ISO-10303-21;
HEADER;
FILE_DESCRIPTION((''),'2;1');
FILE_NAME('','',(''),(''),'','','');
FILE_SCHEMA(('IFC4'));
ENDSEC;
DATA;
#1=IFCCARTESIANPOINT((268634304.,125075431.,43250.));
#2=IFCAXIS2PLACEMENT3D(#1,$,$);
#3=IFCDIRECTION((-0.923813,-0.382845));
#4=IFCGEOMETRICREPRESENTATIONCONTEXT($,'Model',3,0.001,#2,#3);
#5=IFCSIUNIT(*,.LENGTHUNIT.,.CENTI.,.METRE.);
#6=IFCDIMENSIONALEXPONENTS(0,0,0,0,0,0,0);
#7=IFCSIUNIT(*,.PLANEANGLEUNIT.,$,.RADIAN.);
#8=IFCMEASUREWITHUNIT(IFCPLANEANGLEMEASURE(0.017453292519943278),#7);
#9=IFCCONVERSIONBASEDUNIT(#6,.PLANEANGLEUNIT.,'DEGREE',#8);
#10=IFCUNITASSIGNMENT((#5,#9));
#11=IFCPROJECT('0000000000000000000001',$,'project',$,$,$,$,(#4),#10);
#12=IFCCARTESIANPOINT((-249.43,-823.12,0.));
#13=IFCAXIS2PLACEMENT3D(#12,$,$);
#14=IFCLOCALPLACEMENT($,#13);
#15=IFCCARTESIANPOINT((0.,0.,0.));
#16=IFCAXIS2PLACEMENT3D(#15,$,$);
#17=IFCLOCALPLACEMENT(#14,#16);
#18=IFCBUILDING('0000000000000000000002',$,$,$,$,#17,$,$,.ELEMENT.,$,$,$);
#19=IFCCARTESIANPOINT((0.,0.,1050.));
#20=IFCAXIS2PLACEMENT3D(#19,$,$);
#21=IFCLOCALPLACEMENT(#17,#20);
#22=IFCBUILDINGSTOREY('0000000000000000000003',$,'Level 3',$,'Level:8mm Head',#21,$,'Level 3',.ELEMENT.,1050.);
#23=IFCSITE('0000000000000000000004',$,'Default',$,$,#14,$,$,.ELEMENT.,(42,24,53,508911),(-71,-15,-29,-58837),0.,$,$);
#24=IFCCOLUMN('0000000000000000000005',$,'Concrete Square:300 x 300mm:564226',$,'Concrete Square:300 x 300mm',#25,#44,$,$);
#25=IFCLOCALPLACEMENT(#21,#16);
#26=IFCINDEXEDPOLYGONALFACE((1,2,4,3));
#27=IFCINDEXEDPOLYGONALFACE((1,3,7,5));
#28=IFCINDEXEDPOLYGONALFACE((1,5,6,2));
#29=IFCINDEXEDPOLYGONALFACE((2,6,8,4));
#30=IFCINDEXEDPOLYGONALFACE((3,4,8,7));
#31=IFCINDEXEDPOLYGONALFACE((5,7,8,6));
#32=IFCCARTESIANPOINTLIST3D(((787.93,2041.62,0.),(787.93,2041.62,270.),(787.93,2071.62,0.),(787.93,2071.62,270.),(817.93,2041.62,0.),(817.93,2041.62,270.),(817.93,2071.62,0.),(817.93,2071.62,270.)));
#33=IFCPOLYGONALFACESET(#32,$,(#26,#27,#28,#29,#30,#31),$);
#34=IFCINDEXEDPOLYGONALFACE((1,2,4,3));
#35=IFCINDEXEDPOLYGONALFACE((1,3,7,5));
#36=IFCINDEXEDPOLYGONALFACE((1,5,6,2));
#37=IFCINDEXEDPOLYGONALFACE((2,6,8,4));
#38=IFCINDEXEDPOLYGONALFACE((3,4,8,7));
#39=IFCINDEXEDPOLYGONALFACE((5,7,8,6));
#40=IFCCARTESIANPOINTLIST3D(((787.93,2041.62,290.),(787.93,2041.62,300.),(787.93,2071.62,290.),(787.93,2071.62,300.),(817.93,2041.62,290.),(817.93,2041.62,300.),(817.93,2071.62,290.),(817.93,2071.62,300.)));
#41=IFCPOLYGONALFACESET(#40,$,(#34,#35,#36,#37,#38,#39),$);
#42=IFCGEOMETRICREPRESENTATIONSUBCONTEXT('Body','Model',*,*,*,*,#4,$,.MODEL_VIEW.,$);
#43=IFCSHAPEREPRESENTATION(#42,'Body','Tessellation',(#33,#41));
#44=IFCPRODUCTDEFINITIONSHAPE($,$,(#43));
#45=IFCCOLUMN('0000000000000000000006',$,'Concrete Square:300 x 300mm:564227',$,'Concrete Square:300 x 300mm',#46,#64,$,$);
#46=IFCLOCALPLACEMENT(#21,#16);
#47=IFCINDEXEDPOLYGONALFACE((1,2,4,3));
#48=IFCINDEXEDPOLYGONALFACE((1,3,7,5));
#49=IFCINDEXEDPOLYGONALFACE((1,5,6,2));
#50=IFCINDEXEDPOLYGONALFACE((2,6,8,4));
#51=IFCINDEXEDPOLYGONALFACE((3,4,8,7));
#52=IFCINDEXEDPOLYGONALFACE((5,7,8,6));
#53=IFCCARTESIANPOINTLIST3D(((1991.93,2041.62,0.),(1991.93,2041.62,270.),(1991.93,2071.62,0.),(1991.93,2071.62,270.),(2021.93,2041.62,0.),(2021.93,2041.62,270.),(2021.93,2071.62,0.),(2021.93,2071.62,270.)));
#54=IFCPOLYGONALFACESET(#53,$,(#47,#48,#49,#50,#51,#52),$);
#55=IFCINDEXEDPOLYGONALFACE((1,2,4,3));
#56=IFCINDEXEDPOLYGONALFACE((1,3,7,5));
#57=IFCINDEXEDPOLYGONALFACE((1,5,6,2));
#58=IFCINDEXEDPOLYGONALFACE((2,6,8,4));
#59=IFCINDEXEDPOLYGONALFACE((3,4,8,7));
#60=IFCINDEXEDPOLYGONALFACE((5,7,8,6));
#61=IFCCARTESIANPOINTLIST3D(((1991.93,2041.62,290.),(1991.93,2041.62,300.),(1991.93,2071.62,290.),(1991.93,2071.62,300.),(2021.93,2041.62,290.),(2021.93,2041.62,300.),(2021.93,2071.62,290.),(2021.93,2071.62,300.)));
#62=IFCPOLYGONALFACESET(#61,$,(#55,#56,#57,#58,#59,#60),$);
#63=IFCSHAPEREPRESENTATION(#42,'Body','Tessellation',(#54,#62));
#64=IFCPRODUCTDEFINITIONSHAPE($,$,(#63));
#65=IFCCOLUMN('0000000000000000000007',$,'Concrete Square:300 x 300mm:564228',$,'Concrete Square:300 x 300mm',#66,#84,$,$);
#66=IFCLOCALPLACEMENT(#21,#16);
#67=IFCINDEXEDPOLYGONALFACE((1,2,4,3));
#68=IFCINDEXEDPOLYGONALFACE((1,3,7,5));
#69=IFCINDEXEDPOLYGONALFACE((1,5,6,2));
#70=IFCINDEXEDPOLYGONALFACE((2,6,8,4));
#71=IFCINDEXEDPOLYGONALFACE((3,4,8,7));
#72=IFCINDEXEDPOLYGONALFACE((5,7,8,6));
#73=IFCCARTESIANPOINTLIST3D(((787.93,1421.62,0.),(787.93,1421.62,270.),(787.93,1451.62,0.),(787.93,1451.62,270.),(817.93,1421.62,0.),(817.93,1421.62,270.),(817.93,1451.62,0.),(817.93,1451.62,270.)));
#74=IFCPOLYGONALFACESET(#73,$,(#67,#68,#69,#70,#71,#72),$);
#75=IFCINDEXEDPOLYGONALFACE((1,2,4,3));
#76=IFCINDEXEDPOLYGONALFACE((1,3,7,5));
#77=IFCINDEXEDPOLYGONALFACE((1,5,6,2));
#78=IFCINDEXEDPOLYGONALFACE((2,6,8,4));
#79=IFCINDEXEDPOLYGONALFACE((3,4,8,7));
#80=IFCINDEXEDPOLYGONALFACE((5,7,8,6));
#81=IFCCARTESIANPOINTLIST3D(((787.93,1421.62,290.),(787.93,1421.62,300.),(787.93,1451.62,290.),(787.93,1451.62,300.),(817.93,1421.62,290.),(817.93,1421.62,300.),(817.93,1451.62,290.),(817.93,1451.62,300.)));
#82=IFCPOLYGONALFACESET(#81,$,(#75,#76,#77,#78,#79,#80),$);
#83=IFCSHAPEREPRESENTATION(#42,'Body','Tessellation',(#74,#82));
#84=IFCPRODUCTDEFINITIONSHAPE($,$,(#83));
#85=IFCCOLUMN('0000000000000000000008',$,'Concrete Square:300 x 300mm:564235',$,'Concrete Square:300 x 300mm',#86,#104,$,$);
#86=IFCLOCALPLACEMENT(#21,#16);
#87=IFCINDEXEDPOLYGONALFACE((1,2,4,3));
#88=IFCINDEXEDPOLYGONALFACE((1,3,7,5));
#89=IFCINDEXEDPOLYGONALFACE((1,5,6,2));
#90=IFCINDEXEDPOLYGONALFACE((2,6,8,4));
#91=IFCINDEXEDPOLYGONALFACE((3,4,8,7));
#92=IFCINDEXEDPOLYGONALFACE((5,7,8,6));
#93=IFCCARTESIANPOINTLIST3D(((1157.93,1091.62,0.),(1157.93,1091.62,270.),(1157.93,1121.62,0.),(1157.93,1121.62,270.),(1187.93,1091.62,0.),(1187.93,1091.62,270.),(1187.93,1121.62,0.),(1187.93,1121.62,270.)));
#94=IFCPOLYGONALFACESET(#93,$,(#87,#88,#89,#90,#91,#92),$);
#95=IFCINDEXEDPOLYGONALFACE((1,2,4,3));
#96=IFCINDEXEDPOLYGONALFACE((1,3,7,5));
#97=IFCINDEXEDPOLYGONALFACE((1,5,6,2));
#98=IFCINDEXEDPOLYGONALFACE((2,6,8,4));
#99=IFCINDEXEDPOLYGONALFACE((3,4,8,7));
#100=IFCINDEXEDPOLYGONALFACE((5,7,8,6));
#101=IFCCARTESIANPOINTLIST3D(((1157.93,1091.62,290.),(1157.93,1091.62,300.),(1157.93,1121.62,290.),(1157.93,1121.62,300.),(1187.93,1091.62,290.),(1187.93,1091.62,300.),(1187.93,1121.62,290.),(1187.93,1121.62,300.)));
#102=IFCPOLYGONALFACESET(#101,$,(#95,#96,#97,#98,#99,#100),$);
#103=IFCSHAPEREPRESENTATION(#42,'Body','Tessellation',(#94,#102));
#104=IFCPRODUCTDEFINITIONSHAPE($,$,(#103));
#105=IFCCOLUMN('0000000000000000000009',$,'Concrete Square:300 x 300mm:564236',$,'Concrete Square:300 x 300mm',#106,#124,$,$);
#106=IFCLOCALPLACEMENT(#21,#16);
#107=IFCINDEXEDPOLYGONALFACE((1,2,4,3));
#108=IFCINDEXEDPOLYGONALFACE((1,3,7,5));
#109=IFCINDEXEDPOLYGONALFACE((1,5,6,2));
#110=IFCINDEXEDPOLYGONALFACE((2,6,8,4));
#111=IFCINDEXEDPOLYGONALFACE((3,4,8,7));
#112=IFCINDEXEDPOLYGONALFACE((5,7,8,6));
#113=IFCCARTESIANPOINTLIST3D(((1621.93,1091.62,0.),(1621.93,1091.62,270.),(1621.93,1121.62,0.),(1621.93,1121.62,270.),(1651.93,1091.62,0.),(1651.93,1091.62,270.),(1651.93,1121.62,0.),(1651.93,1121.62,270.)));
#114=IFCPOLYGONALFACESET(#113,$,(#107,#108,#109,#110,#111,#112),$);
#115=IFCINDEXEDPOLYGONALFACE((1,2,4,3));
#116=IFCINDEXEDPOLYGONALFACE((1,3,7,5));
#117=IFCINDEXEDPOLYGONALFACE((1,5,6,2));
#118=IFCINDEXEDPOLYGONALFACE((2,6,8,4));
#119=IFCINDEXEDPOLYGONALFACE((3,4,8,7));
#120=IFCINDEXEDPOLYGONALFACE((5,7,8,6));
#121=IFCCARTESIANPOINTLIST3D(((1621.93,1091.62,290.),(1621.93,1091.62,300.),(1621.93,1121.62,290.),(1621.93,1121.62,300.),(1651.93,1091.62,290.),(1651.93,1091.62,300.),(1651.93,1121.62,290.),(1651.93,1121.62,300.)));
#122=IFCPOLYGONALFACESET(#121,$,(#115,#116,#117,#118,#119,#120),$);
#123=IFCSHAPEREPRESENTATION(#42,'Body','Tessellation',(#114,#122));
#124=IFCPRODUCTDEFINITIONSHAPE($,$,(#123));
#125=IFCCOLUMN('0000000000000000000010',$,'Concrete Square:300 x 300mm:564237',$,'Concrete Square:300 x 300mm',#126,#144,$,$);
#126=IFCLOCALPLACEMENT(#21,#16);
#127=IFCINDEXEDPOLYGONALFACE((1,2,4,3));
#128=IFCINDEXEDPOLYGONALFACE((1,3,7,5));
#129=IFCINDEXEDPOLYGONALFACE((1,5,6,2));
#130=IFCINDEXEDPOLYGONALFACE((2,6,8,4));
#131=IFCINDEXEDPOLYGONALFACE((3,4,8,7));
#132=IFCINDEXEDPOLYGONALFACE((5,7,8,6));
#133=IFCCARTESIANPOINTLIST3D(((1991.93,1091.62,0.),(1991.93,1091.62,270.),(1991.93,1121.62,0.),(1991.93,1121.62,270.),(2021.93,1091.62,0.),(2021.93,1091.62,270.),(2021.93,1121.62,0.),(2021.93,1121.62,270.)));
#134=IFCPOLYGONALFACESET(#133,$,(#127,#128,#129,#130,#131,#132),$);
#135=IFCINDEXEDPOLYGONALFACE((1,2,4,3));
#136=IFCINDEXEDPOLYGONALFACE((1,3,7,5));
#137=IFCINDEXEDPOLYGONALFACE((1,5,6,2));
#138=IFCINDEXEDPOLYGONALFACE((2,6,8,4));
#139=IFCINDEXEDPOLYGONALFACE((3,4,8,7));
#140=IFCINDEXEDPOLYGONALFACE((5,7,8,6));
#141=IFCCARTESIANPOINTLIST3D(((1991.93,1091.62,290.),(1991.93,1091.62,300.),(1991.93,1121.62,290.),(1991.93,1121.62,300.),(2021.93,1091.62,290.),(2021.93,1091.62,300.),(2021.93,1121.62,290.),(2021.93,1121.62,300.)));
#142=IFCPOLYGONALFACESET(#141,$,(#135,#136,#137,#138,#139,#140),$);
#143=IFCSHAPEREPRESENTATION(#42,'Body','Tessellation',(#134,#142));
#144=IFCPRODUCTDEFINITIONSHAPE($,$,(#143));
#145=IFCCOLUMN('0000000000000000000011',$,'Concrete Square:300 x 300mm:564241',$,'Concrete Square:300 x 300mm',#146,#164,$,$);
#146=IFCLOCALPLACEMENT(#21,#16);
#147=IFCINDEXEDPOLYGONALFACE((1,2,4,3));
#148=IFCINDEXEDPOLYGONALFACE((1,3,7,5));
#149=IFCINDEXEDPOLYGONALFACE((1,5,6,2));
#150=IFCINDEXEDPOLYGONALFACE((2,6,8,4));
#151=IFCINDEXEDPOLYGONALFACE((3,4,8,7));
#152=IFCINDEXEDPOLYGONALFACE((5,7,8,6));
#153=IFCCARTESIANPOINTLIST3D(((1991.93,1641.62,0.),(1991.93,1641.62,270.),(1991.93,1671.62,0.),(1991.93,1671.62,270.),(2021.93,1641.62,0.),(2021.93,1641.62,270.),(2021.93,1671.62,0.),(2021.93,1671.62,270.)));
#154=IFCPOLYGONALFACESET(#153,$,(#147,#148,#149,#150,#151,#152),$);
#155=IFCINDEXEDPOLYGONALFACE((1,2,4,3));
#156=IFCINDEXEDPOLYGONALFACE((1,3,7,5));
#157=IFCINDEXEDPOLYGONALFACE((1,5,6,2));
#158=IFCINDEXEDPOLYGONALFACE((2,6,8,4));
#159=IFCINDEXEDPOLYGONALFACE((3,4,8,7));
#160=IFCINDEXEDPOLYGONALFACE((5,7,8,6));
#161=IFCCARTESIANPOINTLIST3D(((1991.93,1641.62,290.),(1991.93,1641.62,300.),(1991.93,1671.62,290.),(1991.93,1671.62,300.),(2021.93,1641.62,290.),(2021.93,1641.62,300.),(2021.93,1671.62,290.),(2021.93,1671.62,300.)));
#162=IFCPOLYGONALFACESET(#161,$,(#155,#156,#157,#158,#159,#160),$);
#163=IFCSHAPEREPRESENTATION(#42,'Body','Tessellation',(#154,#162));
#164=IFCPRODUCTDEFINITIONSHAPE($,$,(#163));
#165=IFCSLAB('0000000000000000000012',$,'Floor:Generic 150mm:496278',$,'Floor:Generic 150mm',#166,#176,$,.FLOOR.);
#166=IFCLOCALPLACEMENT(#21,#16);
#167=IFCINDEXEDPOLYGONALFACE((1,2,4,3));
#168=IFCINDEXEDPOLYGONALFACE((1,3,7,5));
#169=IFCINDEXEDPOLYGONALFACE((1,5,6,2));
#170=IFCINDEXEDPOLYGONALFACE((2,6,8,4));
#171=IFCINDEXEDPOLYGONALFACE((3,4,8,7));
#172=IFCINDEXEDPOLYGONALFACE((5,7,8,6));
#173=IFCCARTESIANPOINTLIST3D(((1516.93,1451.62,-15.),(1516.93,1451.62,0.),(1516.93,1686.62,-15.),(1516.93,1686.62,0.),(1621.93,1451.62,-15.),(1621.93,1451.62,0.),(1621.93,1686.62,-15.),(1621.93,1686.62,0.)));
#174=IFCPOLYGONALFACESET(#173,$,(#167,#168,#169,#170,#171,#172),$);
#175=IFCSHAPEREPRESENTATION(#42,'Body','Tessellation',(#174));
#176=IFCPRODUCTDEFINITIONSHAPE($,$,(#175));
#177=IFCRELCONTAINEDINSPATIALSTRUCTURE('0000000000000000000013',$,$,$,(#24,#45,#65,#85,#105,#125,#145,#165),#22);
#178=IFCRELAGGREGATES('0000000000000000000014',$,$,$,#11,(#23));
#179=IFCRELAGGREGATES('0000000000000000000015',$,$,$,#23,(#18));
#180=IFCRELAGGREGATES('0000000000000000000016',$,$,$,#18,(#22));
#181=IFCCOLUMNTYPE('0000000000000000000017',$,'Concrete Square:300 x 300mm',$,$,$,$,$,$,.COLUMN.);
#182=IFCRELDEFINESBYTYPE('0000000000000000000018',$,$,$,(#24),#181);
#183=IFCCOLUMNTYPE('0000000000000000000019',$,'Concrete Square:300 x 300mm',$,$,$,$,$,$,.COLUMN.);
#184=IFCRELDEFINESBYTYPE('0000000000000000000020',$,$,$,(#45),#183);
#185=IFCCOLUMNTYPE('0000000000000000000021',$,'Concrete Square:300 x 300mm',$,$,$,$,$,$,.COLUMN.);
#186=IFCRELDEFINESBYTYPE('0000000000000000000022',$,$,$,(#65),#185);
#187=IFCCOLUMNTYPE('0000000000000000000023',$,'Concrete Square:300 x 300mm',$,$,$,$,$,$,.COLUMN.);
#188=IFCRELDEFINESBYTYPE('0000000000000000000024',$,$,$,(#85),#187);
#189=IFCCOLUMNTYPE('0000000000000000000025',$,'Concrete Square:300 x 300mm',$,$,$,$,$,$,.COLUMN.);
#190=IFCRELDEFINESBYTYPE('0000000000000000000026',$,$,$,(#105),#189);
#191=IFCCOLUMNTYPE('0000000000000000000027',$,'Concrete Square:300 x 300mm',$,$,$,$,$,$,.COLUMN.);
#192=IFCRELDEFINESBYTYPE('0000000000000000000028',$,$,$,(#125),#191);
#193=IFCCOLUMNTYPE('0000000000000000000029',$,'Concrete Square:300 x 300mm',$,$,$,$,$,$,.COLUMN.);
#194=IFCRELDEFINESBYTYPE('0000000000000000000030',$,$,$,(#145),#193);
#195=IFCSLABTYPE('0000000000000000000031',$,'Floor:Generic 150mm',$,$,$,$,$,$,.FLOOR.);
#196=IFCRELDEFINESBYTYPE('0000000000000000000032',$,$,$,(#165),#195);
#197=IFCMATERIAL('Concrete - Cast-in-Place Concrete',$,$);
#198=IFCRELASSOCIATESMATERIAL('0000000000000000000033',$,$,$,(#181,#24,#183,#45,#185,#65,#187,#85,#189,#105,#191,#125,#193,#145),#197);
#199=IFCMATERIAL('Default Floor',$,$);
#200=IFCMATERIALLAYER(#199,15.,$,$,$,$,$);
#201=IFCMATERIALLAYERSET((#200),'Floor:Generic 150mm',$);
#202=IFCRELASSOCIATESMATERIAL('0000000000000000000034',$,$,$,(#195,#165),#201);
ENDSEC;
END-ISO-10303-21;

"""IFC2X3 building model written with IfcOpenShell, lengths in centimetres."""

from ifc_helpers import new_model, entity, si_unit, converted_unit, direction, frame, frame_2d, origin, origin_2d_with_axis, place, context, subcontext, project, spatial, rectangle, extrude, source, transform, mapped, material, layer, layer_set, layer_usage, type_object, type_shapes, element, save


model = new_model("IFC2X3")

# Units and contexts
model_context = context("Model", 3, precision=0.001, world=frame((268634304.0, 125075431.0, 43250.0)), true_north=direction((-0.923813, -0.382845)))
body_context = subcontext(model_context, "Body", "Model", "MODEL_VIEW")
ifc_project = project(units=[si_unit("LENGTHUNIT", "METRE", prefix="CENTI"), converted_unit("PLANEANGLEUNIT", "DEGREE", entity("IfcPlaneAngleMeasure", 0.017453292519943278), si_unit("PLANEANGLEUNIT", "RADIAN"), dimensions=[0, 0, 0, 0, 0, 0, 0])], contexts=[model_context])

# Site, building, storey
site_placement = place(None, frame((-249.43, -823.12, 0.0)))
site = spatial("IfcSite", under=ifc_project, at=site_placement, Name="Default", CompositionType="ELEMENT", RefLatitude=(42, 24, 53, 508911), RefLongitude=(-71, -15, -29, -58837), RefElevation=0.0)
building_placement = place(site_placement, origin())
building = spatial("IfcBuilding", under=site, at=building_placement, CompositionType="ELEMENT")
storey_placement = place(building_placement, frame((0.0, 0.0, 1050.0)))
storey = spatial("IfcBuildingStorey", under=building, at=storey_placement, Name="Level 3", ObjectType="Level:8mm Head", LongName="Level 3", CompositionType="ELEMENT", Elevation=1050.0)

# Columns
ifc_material_1 = material(Name="Concrete - Cast-in-Place Concrete")
column_type_1 = type_object("IfcColumnType", Name="Concrete Square:300 x 300mm", PredefinedType="COLUMN", material=ifc_material_1)
shared_shape_1 = source(origin(), body_context, "Body", "SweptSolid", [
    extrude(rectangle(XDim=30.0, YDim=30.0, at=frame_2d((0.0, 0.0), x_axis=(1.0, 0.0))), frame((802.93, 2056.62, 1050.0), z_axis=(0.0, 0.0, 1.0), x_axis=(-1.0, 0.0, 0.0)), (0.0, 0.0, 1.0), 270.0),
    extrude(rectangle(XDim=30.0, YDim=30.0, at=frame_2d((0.0, 0.0), x_axis=(1.0, 0.0))), frame((802.93, 2056.62, 1340.0), z_axis=(0.0, 0.0, 1.0), x_axis=(-1.0, 0.0, 0.0)), (0.0, 0.0, 1.0), 10.0),
])
type_shapes(column_type_1, [shared_shape_1])
column_1_placement = place(storey_placement, frame((0.0, 0.0, -1050.0)))
element("IfcColumn", 1, at=column_1_placement, inside=storey, type_object=column_type_1, material=ifc_material_1, Name="Concrete Square:300 x 300mm:564226", ObjectType="Concrete Square:300 x 300mm", context=body_context, shape_type="MappedRepresentation", body=[
    mapped(shared_shape_1, transform((0.0, 0.0, 0.0), scale=1.0)),
])
column_type_2 = type_object("IfcColumnType", Name="Concrete Square:300 x 300mm", PredefinedType="COLUMN", material=ifc_material_1)
shared_shape_2 = source(origin(), body_context, "Body", "SweptSolid", [
    extrude(rectangle(XDim=30.0, YDim=30.0, at=origin_2d_with_axis()), frame((2006.93, 2056.62, 1050.0), z_axis=(0.0, 0.0, 1.0), x_axis=(-1.0, 0.0, 0.0)), (0.0, 0.0, 1.0), 270.0),
    extrude(rectangle(XDim=30.0, YDim=30.0, at=origin_2d_with_axis()), frame((2006.93, 2056.62, 1340.0), z_axis=(0.0, 0.0, 1.0), x_axis=(-1.0, 0.0, 0.0)), (0.0, 0.0, 1.0), 10.0),
])
type_shapes(column_type_2, [shared_shape_2])
column_2_placement = place(storey_placement, frame((0.0, 0.0, -1050.0)))
element("IfcColumn", 2, at=column_2_placement, inside=storey, type_object=column_type_2, material=ifc_material_1, Name="Concrete Square:300 x 300mm:564227", ObjectType="Concrete Square:300 x 300mm", context=body_context, shape_type="MappedRepresentation", body=[
    mapped(shared_shape_2, transform((0.0, 0.0, 0.0), scale=1.0)),
])
column_type_3 = type_object("IfcColumnType", Name="Concrete Square:300 x 300mm", PredefinedType="COLUMN", material=ifc_material_1)
shared_shape_3 = source(origin(), body_context, "Body", "SweptSolid", [
    extrude(rectangle(XDim=30.0, YDim=30.0, at=frame_2d((0.0, 0.0), x_axis=(1.0, 0.0))), frame((802.93, 1436.62, 1050.0), z_axis=(0.0, 0.0, 1.0), x_axis=(-1.0, 0.0, 0.0)), (0.0, 0.0, 1.0), 270.0),
    extrude(rectangle(XDim=30.0, YDim=30.0, at=frame_2d((0.0, 0.0), x_axis=(1.0, 0.0))), frame((802.93, 1436.62, 1340.0), z_axis=(0.0, 0.0, 1.0), x_axis=(-1.0, 0.0, 0.0)), (0.0, 0.0, 1.0), 10.0),
])
type_shapes(column_type_3, [shared_shape_3])
column_3_placement = place(storey_placement, frame((0.0, 0.0, -1050.0)))
element("IfcColumn", 3, at=column_3_placement, inside=storey, type_object=column_type_3, material=ifc_material_1, Name="Concrete Square:300 x 300mm:564228", ObjectType="Concrete Square:300 x 300mm", context=body_context, shape_type="MappedRepresentation", body=[
    mapped(shared_shape_3, transform((0.0, 0.0, 0.0), scale=1.0)),
])
column_type_4 = type_object("IfcColumnType", Name="Concrete Square:300 x 300mm", PredefinedType="COLUMN", material=ifc_material_1)
shared_shape_4 = source(origin(), body_context, "Body", "SweptSolid", [
    extrude(rectangle(XDim=30.0, YDim=30.0, at=frame_2d((0.0, 0.0), x_axis=(1.0, 0.0))), frame((1172.93, 1106.62, 1050.0), z_axis=(0.0, 0.0, 1.0), x_axis=(-1.0, 0.0, 0.0)), (0.0, 0.0, 1.0), 270.0),
    extrude(rectangle(XDim=30.0, YDim=30.0, at=origin_2d_with_axis()), frame((1172.93, 1106.62, 1340.0), z_axis=(0.0, 0.0, 1.0), x_axis=(-1.0, 0.0, 0.0)), (0.0, 0.0, 1.0), 10.0),
])
type_shapes(column_type_4, [shared_shape_4])
column_4_placement = place(storey_placement, frame((0.0, 0.0, -1050.0)))
element("IfcColumn", 4, at=column_4_placement, inside=storey, type_object=column_type_4, material=ifc_material_1, Name="Concrete Square:300 x 300mm:564235", ObjectType="Concrete Square:300 x 300mm", context=body_context, shape_type="MappedRepresentation", body=[
    mapped(shared_shape_4, transform((0.0, 0.0, 0.0), scale=1.0)),
])
column_type_5 = type_object("IfcColumnType", Name="Concrete Square:300 x 300mm", PredefinedType="COLUMN", material=ifc_material_1)
shared_shape_5 = source(origin(), body_context, "Body", "SweptSolid", [
    extrude(rectangle(XDim=30.0, YDim=30.0, at=frame_2d((0.0, 0.0), x_axis=(1.0, 0.0))), frame((1636.93, 1106.62, 1050.0), z_axis=(0.0, 0.0, 1.0), x_axis=(-1.0, 0.0, 0.0)), (0.0, 0.0, 1.0), 270.0),
    extrude(rectangle(XDim=30.0, YDim=30.0, at=origin_2d_with_axis()), frame((1636.93, 1106.62, 1340.0), z_axis=(0.0, 0.0, 1.0), x_axis=(-1.0, 0.0, 0.0)), (0.0, 0.0, 1.0), 10.0),
])
type_shapes(column_type_5, [shared_shape_5])
column_5_placement = place(storey_placement, frame((0.0, 0.0, -1050.0)))
element("IfcColumn", 5, at=column_5_placement, inside=storey, type_object=column_type_5, material=ifc_material_1, Name="Concrete Square:300 x 300mm:564236", ObjectType="Concrete Square:300 x 300mm", context=body_context, shape_type="MappedRepresentation", body=[
    mapped(shared_shape_5, transform((0.0, 0.0, 0.0), scale=1.0)),
])
column_type_6 = type_object("IfcColumnType", Name="Concrete Square:300 x 300mm", PredefinedType="COLUMN", material=ifc_material_1)
shared_shape_6 = source(origin(), body_context, "Body", "SweptSolid", [
    extrude(rectangle(XDim=30.0, YDim=30.0, at=frame_2d((0.0, 0.0), x_axis=(1.0, 0.0))), frame((2006.93, 1106.62, 1050.0), z_axis=(0.0, 0.0, 1.0), x_axis=(-1.0, 0.0, 0.0)), (0.0, 0.0, 1.0), 270.0),
    extrude(rectangle(XDim=30.0, YDim=30.0, at=origin_2d_with_axis()), frame((2006.93, 1106.62, 1340.0), z_axis=(0.0, 0.0, 1.0), x_axis=(-1.0, 0.0, 0.0)), (0.0, 0.0, 1.0), 10.0),
])
type_shapes(column_type_6, [shared_shape_6])
column_6_placement = place(storey_placement, frame((0.0, 0.0, -1050.0)))
element("IfcColumn", 6, at=column_6_placement, inside=storey, type_object=column_type_6, material=ifc_material_1, Name="Concrete Square:300 x 300mm:564237", ObjectType="Concrete Square:300 x 300mm", context=body_context, shape_type="MappedRepresentation", body=[
    mapped(shared_shape_6, transform((0.0, 0.0, 0.0), scale=1.0)),
])
column_type_7 = type_object("IfcColumnType", Name="Concrete Square:300 x 300mm", PredefinedType="COLUMN", material=ifc_material_1)
shared_shape_7 = source(origin(), body_context, "Body", "SweptSolid", [
    extrude(rectangle(XDim=30.0, YDim=30.0, at=frame_2d((0.0, 0.0), x_axis=(1.0, 0.0))), frame((2006.93, 1656.62, 1050.0), z_axis=(0.0, 0.0, 1.0), x_axis=(-1.0, 0.0, 0.0)), (0.0, 0.0, 1.0), 270.0),
    extrude(rectangle(XDim=30.0, YDim=30.0, at=origin_2d_with_axis()), frame((2006.93, 1656.62, 1340.0), z_axis=(0.0, 0.0, 1.0), x_axis=(-1.0, 0.0, 0.0)), (0.0, 0.0, 1.0), 10.0),
])
type_shapes(column_type_7, [shared_shape_7])
column_7_placement = place(storey_placement, frame((0.0, 0.0, -1050.0)))
element("IfcColumn", 7, at=column_7_placement, inside=storey, type_object=column_type_7, material=ifc_material_1, Name="Concrete Square:300 x 300mm:564241", ObjectType="Concrete Square:300 x 300mm", context=body_context, shape_type="MappedRepresentation", body=[
    mapped(shared_shape_7, transform((0.0, 0.0, 0.0), scale=1.0)),
])

# Slab
ifc_material_2 = material(Name="Default Floor")
ifc_layer_1 = layer(ifc_material_2, 15.0)
ifc_layer_set_1 = layer_set([ifc_layer_1], Name="Floor:Generic 150mm")
ifc_layer_usage_1 = layer_usage(ifc_layer_set_1, "AXIS3", "POSITIVE", 0.0)
slab_type_1 = type_object("IfcSlabType", Name="Floor:Generic 150mm", PredefinedType="FLOOR", material=ifc_layer_set_1)
slab_1_placement = place(storey_placement, origin())
element("IfcSlab", 8, at=slab_1_placement, inside=storey, type_object=slab_type_1, material=ifc_layer_usage_1, Name="Floor:Generic 150mm:496278", ObjectType="Floor:Generic 150mm", PredefinedType="FLOOR", context=body_context, shape_type="SweptSolid", body=[
    extrude(rectangle(XDim=235.0, YDim=105.0, at=origin_2d_with_axis()), frame((1569.43, 1569.12, 0.0), z_axis=(0.0, 0.0, -1.0), x_axis=(0.0, 1.0, 0.0)), (0.0, 0.0, 1.0), 15.0),
])

save(model, "model.ifc")
